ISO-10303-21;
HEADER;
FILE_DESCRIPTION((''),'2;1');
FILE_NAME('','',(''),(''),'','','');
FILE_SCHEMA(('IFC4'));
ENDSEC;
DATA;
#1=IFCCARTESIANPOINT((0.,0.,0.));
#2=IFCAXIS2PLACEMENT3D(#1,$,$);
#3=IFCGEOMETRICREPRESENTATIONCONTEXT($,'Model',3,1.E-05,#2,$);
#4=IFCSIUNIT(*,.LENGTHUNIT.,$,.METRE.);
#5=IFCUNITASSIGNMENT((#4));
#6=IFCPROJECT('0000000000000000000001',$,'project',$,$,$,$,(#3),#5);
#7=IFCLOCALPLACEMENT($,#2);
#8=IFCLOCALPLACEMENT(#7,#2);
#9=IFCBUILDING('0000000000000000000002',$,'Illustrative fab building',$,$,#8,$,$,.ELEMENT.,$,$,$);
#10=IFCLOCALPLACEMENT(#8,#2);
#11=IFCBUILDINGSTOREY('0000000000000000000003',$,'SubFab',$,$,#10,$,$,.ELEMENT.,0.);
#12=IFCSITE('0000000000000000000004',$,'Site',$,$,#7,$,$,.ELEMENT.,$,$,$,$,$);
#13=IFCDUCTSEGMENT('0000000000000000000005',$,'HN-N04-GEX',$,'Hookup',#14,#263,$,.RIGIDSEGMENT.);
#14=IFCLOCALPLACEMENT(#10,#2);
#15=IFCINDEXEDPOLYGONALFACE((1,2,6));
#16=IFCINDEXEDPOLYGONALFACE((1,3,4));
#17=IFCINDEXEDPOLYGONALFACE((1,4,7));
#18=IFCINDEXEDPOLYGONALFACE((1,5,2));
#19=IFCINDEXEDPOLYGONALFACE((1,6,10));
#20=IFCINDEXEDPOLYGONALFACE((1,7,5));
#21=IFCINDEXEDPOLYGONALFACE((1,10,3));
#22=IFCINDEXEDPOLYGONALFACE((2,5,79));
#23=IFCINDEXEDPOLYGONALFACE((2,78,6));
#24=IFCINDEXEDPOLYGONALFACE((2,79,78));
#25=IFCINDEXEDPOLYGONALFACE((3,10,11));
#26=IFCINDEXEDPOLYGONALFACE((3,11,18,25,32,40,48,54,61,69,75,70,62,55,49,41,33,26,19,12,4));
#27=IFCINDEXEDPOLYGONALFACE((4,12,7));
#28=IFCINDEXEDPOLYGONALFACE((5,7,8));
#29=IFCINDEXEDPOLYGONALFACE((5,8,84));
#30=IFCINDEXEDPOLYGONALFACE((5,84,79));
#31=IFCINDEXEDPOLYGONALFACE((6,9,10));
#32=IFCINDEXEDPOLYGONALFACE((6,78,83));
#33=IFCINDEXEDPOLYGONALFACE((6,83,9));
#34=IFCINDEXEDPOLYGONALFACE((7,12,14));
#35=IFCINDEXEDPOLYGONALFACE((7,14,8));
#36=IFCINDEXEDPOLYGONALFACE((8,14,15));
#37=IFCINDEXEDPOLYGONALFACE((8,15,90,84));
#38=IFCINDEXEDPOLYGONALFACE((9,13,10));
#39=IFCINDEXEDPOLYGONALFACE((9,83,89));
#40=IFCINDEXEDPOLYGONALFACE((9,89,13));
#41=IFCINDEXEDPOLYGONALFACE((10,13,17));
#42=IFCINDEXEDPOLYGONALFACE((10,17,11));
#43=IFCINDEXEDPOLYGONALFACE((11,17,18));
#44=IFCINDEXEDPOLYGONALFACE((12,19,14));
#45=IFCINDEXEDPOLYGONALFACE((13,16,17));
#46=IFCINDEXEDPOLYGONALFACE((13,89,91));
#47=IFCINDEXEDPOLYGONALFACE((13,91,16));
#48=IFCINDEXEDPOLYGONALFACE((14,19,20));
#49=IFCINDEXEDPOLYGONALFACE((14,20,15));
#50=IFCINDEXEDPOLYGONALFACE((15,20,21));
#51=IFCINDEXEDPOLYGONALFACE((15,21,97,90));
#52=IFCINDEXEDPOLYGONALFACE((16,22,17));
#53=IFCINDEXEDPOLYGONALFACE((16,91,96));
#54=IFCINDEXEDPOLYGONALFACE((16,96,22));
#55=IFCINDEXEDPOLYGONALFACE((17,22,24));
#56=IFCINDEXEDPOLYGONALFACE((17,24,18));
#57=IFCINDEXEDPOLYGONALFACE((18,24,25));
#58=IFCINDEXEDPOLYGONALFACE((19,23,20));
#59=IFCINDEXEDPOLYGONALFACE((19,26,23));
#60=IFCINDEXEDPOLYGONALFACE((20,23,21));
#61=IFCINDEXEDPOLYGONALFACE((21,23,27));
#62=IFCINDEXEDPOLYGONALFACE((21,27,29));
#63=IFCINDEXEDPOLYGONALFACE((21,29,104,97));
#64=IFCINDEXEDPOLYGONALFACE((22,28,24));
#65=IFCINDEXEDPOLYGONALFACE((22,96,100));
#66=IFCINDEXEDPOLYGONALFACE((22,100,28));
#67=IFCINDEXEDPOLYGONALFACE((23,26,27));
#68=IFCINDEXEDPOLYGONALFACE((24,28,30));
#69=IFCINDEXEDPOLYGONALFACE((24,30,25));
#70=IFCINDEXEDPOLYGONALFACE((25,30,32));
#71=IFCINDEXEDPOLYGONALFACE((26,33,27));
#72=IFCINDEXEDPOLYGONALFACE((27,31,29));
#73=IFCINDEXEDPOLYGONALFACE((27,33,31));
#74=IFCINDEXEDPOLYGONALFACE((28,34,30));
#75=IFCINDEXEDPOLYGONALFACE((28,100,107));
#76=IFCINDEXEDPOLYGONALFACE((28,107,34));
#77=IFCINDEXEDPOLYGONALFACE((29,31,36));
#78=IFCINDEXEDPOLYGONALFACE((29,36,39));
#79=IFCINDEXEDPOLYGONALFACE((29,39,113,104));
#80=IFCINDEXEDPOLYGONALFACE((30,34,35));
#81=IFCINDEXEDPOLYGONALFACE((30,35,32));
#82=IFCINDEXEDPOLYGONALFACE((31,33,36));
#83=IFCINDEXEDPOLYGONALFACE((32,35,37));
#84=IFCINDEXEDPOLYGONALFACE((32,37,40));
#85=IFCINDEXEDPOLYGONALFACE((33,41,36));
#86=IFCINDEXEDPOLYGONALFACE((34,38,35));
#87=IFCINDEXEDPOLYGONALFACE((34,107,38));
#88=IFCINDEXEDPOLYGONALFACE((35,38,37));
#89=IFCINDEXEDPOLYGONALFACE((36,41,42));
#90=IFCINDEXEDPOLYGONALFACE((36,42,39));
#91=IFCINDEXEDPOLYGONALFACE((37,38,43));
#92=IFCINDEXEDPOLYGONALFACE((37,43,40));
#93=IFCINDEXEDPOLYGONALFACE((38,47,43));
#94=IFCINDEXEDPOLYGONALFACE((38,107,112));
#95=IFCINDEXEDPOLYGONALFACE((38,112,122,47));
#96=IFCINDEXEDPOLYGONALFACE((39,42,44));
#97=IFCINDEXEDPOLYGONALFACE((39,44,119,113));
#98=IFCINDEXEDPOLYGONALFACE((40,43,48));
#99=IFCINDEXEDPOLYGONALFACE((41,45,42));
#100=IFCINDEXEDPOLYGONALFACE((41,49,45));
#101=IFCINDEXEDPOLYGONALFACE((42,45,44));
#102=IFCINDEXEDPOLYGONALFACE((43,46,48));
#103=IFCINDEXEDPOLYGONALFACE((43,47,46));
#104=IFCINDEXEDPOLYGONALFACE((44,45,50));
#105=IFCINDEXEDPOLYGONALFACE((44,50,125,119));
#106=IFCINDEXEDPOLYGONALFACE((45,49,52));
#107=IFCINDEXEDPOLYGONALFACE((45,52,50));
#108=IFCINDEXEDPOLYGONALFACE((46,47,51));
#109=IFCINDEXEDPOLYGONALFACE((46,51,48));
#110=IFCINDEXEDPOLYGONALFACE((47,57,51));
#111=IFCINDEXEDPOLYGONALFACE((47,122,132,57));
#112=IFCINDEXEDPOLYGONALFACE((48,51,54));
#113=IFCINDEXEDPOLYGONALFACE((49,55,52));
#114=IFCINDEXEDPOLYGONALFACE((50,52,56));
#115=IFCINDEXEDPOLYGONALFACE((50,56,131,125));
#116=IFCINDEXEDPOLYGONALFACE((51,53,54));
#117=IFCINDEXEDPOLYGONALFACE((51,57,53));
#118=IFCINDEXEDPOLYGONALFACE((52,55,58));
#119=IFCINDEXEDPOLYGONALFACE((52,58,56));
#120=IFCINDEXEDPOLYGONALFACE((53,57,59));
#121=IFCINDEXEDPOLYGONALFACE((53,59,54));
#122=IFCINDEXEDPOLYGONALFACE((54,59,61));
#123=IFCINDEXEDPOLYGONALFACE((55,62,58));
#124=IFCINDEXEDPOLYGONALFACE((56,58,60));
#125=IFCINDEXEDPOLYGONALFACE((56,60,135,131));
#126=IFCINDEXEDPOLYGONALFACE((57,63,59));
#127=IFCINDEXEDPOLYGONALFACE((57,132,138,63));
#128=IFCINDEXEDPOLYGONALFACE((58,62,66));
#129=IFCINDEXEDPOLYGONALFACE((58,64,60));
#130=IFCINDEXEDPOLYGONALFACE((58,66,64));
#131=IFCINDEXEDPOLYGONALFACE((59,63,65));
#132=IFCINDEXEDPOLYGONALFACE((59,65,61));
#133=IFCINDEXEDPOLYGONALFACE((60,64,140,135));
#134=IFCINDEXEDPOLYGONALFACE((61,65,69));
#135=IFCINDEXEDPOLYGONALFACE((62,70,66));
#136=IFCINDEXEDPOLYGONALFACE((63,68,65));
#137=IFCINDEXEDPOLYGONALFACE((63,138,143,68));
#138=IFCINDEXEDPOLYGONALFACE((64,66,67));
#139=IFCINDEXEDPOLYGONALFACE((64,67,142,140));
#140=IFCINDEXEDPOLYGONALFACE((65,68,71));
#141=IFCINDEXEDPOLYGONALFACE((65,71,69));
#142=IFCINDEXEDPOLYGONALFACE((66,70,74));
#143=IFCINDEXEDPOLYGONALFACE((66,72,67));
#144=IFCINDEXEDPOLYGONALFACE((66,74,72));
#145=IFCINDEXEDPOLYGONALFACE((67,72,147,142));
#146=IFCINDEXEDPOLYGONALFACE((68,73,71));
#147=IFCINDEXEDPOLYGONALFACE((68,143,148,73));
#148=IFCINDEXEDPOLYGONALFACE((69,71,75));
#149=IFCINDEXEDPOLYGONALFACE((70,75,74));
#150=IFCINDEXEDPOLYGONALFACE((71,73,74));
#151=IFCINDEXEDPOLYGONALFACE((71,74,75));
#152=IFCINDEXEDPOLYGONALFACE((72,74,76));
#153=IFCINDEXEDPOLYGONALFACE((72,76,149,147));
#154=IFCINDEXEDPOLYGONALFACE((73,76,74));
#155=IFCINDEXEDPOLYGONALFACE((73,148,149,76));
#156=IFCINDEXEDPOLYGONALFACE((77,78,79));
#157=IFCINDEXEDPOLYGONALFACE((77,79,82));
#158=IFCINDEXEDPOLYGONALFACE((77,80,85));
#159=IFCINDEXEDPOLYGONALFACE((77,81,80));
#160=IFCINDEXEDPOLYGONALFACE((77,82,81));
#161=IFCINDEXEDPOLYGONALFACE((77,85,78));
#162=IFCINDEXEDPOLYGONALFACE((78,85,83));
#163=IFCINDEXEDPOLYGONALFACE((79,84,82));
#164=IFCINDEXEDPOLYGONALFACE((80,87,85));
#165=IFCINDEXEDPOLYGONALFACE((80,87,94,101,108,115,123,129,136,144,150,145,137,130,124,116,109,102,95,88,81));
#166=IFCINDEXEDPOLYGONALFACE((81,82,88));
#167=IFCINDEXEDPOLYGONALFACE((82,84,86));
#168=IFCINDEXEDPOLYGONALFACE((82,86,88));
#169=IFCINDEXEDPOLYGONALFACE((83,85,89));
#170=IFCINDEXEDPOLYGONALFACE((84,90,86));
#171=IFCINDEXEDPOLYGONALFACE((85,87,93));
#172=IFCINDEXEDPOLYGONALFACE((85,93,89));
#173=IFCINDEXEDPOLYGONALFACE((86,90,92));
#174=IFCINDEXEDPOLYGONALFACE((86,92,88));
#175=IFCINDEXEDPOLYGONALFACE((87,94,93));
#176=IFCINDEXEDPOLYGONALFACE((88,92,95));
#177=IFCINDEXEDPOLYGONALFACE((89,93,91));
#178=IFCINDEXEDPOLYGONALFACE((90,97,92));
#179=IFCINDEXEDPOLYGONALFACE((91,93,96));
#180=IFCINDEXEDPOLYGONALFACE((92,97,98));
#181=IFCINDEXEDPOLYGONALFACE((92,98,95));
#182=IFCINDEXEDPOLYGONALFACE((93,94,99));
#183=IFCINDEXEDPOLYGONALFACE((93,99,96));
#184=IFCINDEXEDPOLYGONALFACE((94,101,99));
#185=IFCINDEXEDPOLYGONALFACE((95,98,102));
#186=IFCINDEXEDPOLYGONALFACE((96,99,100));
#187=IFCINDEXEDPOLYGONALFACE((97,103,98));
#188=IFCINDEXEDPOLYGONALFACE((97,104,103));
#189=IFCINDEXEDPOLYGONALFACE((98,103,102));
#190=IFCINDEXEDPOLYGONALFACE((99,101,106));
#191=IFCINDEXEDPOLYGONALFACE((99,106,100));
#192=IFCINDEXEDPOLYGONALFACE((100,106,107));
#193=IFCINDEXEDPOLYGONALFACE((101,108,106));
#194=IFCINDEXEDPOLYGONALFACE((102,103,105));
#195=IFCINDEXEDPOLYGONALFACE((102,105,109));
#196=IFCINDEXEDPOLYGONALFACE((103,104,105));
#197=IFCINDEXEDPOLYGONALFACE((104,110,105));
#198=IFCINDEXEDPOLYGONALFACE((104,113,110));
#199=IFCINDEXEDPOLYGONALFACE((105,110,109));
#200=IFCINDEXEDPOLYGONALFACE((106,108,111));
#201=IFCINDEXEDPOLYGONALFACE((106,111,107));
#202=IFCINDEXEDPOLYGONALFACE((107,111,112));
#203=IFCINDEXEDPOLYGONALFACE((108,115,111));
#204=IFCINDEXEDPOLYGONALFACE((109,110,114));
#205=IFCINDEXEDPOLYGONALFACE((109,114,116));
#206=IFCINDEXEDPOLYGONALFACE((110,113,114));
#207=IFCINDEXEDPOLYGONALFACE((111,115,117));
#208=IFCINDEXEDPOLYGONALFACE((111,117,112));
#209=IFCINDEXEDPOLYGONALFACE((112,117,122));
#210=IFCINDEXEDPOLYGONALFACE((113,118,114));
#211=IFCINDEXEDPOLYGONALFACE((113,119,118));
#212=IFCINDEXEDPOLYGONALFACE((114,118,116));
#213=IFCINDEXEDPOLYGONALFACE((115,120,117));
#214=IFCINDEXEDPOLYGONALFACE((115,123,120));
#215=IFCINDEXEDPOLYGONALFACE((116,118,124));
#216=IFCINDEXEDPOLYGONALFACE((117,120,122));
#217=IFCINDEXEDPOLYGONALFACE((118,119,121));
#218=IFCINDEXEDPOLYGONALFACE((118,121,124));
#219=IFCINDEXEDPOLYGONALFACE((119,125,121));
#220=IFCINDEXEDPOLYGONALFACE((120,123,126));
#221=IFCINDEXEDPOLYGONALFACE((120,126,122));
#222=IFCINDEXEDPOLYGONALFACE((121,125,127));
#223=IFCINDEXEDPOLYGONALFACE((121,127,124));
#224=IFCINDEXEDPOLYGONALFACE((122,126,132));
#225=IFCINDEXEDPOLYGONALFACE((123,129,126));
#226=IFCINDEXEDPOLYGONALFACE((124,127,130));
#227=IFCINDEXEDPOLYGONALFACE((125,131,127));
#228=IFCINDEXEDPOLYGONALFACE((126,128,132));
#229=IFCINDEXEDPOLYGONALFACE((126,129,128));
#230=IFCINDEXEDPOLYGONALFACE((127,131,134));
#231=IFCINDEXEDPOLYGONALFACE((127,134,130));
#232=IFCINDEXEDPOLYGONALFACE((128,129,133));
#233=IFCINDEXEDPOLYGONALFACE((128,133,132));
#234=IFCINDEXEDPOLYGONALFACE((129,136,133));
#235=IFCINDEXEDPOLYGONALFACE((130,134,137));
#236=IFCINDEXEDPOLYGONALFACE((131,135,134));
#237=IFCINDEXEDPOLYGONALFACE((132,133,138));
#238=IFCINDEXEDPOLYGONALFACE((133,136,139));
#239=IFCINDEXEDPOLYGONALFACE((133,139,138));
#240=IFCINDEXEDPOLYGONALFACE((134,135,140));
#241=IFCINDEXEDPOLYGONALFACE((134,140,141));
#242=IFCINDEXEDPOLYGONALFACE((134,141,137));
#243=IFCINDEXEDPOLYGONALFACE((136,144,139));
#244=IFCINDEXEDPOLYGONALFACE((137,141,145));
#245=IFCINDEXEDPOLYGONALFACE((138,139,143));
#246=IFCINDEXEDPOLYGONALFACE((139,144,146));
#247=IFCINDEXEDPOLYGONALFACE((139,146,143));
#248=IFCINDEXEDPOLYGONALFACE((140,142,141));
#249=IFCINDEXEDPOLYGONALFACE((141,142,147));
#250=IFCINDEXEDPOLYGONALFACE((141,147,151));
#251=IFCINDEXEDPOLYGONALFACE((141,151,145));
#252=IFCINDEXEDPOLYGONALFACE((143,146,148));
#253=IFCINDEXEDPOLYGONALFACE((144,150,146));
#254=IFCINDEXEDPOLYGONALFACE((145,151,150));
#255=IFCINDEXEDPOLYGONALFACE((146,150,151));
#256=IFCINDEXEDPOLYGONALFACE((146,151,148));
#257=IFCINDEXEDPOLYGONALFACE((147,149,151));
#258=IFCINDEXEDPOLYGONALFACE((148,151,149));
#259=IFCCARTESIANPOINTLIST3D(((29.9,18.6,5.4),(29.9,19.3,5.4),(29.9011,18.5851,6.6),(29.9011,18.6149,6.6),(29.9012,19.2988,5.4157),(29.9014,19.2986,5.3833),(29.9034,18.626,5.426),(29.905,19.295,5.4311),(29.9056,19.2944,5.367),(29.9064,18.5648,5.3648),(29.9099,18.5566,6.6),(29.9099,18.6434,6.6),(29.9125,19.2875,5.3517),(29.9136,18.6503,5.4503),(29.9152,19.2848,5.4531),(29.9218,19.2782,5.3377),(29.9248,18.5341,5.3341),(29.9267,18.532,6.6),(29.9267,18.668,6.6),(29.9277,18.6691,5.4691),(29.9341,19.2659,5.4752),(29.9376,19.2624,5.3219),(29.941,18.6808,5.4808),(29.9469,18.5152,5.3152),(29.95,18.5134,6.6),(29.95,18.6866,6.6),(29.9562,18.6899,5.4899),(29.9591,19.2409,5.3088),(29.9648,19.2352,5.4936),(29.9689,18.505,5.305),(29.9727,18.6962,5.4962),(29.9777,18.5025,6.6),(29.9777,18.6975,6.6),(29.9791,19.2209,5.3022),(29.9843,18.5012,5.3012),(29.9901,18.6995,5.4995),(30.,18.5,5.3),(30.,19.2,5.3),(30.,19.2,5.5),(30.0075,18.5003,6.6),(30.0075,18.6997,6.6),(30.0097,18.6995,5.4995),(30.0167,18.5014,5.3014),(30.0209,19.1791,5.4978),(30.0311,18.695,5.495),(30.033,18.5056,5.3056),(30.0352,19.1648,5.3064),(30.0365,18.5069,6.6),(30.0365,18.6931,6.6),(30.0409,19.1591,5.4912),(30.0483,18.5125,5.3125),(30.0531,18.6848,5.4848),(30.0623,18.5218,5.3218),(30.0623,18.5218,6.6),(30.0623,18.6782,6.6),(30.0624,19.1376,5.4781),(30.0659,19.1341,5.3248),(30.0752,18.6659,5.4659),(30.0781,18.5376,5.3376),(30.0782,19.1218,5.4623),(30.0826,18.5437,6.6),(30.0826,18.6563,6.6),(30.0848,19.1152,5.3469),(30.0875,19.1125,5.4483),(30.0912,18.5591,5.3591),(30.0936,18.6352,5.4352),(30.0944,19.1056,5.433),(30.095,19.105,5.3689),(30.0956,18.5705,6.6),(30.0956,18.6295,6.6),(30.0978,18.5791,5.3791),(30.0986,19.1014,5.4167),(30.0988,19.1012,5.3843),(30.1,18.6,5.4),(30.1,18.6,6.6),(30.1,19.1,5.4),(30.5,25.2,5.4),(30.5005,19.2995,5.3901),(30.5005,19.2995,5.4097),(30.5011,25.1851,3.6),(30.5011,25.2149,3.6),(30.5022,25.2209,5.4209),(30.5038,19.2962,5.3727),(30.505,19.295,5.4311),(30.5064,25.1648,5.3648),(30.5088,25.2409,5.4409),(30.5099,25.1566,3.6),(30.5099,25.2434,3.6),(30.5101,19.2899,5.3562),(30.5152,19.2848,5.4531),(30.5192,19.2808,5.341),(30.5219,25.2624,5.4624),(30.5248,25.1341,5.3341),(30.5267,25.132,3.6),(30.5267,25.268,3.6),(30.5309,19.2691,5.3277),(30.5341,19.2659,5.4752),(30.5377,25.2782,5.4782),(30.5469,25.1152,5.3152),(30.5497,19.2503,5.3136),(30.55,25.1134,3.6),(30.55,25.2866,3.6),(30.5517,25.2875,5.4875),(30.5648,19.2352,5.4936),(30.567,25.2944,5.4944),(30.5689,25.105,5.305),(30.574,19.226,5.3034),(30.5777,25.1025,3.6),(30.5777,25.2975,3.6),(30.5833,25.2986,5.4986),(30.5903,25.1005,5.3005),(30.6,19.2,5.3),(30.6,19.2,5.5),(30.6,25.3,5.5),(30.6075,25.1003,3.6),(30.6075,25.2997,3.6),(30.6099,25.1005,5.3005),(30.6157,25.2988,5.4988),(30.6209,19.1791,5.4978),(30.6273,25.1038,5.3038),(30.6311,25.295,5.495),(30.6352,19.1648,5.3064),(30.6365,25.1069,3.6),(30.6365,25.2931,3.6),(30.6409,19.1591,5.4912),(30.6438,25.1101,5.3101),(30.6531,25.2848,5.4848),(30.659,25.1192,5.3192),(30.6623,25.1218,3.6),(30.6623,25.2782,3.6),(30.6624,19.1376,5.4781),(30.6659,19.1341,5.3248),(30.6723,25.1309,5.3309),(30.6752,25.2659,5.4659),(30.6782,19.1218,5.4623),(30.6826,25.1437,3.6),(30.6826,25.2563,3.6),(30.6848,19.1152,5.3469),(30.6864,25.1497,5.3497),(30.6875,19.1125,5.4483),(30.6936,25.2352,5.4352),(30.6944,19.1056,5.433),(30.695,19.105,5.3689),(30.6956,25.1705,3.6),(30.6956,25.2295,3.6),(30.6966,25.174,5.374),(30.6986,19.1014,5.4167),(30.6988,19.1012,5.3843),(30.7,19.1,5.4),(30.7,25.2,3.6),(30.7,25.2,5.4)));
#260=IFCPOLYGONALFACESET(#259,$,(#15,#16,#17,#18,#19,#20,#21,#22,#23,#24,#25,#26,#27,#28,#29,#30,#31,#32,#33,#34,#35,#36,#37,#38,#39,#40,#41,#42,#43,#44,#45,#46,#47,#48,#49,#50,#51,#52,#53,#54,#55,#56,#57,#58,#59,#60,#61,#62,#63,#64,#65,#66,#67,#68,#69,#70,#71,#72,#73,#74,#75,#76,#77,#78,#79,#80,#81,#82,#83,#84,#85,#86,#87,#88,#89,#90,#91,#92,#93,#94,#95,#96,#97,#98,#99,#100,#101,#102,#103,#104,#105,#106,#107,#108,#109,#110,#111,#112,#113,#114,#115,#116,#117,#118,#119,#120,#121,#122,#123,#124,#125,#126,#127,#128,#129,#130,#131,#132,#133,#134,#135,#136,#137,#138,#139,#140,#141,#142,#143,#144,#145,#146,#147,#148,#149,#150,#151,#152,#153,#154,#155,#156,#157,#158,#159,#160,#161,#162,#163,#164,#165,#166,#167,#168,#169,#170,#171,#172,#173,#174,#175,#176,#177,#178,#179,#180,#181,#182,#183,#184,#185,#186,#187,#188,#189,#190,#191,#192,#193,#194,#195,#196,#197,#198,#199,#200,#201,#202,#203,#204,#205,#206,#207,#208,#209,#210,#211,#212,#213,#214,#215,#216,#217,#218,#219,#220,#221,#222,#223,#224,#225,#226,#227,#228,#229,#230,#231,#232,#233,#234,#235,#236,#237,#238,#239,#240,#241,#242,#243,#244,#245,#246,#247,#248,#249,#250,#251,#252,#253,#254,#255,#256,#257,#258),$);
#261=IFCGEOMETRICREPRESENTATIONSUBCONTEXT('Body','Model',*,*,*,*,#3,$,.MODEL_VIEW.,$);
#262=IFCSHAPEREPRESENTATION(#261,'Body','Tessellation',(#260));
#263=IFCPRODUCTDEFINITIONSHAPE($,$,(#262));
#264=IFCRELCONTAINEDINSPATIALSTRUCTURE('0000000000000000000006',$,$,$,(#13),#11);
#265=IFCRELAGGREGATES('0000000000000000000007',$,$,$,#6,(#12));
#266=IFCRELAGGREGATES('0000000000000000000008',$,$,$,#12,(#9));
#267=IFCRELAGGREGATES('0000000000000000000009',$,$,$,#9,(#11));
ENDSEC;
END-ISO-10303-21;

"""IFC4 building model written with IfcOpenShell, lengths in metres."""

from ifc_helpers import new_model, entity, si_unit, origin, place, context, subcontext, project, spatial, element, save


model = new_model("IFC4")

# Units and contexts
model_context = context("Model", 3, precision=1e-05, world=origin())
body_context = subcontext(model_context, "Body", "Model", "MODEL_VIEW")
ifc_project = project(units=[si_unit("LENGTHUNIT", "METRE")], contexts=[model_context])

# Site, building, storey
site_placement = place(None, origin())
site = spatial("IfcSite", under=ifc_project, at=site_placement, Name="Site", CompositionType="ELEMENT")
building_placement = place(site_placement, origin())
building = spatial("IfcBuilding", under=site, at=building_placement, Name="Illustrative fab building", CompositionType="ELEMENT")
storey_placement = place(building_placement, origin())
storey = spatial("IfcBuildingStorey", under=building, at=storey_placement, Name="SubFab", CompositionType="ELEMENT", Elevation=0.0)

# Duct segment
duct_segment_1_placement = place(storey_placement, origin())
element("IfcDuctSegment", 1, at=duct_segment_1_placement, inside=storey, Name="HN-N04-GEX", ObjectType="Hookup", PredefinedType="RIGIDSEGMENT", context=body_context, shape_type="AdvancedSweptSolid", body=[
    entity("IfcSweptDiskSolid", entity("IfcPolyline", [entity("IfcCartesianPoint", [30.6, 25.2, 3.6]), entity("IfcCartesianPoint", [30.6, 25.2, 5.4]), entity("IfcCartesianPoint", [30.6, 19.2, 5.4]), entity("IfcCartesianPoint", [30.0, 19.2, 5.4]), entity("IfcCartesianPoint", [30.0, 18.6, 5.4]), entity("IfcCartesianPoint", [30.0, 18.6, 6.6])]), 0.1),
])

save(model, "model.ifc")
